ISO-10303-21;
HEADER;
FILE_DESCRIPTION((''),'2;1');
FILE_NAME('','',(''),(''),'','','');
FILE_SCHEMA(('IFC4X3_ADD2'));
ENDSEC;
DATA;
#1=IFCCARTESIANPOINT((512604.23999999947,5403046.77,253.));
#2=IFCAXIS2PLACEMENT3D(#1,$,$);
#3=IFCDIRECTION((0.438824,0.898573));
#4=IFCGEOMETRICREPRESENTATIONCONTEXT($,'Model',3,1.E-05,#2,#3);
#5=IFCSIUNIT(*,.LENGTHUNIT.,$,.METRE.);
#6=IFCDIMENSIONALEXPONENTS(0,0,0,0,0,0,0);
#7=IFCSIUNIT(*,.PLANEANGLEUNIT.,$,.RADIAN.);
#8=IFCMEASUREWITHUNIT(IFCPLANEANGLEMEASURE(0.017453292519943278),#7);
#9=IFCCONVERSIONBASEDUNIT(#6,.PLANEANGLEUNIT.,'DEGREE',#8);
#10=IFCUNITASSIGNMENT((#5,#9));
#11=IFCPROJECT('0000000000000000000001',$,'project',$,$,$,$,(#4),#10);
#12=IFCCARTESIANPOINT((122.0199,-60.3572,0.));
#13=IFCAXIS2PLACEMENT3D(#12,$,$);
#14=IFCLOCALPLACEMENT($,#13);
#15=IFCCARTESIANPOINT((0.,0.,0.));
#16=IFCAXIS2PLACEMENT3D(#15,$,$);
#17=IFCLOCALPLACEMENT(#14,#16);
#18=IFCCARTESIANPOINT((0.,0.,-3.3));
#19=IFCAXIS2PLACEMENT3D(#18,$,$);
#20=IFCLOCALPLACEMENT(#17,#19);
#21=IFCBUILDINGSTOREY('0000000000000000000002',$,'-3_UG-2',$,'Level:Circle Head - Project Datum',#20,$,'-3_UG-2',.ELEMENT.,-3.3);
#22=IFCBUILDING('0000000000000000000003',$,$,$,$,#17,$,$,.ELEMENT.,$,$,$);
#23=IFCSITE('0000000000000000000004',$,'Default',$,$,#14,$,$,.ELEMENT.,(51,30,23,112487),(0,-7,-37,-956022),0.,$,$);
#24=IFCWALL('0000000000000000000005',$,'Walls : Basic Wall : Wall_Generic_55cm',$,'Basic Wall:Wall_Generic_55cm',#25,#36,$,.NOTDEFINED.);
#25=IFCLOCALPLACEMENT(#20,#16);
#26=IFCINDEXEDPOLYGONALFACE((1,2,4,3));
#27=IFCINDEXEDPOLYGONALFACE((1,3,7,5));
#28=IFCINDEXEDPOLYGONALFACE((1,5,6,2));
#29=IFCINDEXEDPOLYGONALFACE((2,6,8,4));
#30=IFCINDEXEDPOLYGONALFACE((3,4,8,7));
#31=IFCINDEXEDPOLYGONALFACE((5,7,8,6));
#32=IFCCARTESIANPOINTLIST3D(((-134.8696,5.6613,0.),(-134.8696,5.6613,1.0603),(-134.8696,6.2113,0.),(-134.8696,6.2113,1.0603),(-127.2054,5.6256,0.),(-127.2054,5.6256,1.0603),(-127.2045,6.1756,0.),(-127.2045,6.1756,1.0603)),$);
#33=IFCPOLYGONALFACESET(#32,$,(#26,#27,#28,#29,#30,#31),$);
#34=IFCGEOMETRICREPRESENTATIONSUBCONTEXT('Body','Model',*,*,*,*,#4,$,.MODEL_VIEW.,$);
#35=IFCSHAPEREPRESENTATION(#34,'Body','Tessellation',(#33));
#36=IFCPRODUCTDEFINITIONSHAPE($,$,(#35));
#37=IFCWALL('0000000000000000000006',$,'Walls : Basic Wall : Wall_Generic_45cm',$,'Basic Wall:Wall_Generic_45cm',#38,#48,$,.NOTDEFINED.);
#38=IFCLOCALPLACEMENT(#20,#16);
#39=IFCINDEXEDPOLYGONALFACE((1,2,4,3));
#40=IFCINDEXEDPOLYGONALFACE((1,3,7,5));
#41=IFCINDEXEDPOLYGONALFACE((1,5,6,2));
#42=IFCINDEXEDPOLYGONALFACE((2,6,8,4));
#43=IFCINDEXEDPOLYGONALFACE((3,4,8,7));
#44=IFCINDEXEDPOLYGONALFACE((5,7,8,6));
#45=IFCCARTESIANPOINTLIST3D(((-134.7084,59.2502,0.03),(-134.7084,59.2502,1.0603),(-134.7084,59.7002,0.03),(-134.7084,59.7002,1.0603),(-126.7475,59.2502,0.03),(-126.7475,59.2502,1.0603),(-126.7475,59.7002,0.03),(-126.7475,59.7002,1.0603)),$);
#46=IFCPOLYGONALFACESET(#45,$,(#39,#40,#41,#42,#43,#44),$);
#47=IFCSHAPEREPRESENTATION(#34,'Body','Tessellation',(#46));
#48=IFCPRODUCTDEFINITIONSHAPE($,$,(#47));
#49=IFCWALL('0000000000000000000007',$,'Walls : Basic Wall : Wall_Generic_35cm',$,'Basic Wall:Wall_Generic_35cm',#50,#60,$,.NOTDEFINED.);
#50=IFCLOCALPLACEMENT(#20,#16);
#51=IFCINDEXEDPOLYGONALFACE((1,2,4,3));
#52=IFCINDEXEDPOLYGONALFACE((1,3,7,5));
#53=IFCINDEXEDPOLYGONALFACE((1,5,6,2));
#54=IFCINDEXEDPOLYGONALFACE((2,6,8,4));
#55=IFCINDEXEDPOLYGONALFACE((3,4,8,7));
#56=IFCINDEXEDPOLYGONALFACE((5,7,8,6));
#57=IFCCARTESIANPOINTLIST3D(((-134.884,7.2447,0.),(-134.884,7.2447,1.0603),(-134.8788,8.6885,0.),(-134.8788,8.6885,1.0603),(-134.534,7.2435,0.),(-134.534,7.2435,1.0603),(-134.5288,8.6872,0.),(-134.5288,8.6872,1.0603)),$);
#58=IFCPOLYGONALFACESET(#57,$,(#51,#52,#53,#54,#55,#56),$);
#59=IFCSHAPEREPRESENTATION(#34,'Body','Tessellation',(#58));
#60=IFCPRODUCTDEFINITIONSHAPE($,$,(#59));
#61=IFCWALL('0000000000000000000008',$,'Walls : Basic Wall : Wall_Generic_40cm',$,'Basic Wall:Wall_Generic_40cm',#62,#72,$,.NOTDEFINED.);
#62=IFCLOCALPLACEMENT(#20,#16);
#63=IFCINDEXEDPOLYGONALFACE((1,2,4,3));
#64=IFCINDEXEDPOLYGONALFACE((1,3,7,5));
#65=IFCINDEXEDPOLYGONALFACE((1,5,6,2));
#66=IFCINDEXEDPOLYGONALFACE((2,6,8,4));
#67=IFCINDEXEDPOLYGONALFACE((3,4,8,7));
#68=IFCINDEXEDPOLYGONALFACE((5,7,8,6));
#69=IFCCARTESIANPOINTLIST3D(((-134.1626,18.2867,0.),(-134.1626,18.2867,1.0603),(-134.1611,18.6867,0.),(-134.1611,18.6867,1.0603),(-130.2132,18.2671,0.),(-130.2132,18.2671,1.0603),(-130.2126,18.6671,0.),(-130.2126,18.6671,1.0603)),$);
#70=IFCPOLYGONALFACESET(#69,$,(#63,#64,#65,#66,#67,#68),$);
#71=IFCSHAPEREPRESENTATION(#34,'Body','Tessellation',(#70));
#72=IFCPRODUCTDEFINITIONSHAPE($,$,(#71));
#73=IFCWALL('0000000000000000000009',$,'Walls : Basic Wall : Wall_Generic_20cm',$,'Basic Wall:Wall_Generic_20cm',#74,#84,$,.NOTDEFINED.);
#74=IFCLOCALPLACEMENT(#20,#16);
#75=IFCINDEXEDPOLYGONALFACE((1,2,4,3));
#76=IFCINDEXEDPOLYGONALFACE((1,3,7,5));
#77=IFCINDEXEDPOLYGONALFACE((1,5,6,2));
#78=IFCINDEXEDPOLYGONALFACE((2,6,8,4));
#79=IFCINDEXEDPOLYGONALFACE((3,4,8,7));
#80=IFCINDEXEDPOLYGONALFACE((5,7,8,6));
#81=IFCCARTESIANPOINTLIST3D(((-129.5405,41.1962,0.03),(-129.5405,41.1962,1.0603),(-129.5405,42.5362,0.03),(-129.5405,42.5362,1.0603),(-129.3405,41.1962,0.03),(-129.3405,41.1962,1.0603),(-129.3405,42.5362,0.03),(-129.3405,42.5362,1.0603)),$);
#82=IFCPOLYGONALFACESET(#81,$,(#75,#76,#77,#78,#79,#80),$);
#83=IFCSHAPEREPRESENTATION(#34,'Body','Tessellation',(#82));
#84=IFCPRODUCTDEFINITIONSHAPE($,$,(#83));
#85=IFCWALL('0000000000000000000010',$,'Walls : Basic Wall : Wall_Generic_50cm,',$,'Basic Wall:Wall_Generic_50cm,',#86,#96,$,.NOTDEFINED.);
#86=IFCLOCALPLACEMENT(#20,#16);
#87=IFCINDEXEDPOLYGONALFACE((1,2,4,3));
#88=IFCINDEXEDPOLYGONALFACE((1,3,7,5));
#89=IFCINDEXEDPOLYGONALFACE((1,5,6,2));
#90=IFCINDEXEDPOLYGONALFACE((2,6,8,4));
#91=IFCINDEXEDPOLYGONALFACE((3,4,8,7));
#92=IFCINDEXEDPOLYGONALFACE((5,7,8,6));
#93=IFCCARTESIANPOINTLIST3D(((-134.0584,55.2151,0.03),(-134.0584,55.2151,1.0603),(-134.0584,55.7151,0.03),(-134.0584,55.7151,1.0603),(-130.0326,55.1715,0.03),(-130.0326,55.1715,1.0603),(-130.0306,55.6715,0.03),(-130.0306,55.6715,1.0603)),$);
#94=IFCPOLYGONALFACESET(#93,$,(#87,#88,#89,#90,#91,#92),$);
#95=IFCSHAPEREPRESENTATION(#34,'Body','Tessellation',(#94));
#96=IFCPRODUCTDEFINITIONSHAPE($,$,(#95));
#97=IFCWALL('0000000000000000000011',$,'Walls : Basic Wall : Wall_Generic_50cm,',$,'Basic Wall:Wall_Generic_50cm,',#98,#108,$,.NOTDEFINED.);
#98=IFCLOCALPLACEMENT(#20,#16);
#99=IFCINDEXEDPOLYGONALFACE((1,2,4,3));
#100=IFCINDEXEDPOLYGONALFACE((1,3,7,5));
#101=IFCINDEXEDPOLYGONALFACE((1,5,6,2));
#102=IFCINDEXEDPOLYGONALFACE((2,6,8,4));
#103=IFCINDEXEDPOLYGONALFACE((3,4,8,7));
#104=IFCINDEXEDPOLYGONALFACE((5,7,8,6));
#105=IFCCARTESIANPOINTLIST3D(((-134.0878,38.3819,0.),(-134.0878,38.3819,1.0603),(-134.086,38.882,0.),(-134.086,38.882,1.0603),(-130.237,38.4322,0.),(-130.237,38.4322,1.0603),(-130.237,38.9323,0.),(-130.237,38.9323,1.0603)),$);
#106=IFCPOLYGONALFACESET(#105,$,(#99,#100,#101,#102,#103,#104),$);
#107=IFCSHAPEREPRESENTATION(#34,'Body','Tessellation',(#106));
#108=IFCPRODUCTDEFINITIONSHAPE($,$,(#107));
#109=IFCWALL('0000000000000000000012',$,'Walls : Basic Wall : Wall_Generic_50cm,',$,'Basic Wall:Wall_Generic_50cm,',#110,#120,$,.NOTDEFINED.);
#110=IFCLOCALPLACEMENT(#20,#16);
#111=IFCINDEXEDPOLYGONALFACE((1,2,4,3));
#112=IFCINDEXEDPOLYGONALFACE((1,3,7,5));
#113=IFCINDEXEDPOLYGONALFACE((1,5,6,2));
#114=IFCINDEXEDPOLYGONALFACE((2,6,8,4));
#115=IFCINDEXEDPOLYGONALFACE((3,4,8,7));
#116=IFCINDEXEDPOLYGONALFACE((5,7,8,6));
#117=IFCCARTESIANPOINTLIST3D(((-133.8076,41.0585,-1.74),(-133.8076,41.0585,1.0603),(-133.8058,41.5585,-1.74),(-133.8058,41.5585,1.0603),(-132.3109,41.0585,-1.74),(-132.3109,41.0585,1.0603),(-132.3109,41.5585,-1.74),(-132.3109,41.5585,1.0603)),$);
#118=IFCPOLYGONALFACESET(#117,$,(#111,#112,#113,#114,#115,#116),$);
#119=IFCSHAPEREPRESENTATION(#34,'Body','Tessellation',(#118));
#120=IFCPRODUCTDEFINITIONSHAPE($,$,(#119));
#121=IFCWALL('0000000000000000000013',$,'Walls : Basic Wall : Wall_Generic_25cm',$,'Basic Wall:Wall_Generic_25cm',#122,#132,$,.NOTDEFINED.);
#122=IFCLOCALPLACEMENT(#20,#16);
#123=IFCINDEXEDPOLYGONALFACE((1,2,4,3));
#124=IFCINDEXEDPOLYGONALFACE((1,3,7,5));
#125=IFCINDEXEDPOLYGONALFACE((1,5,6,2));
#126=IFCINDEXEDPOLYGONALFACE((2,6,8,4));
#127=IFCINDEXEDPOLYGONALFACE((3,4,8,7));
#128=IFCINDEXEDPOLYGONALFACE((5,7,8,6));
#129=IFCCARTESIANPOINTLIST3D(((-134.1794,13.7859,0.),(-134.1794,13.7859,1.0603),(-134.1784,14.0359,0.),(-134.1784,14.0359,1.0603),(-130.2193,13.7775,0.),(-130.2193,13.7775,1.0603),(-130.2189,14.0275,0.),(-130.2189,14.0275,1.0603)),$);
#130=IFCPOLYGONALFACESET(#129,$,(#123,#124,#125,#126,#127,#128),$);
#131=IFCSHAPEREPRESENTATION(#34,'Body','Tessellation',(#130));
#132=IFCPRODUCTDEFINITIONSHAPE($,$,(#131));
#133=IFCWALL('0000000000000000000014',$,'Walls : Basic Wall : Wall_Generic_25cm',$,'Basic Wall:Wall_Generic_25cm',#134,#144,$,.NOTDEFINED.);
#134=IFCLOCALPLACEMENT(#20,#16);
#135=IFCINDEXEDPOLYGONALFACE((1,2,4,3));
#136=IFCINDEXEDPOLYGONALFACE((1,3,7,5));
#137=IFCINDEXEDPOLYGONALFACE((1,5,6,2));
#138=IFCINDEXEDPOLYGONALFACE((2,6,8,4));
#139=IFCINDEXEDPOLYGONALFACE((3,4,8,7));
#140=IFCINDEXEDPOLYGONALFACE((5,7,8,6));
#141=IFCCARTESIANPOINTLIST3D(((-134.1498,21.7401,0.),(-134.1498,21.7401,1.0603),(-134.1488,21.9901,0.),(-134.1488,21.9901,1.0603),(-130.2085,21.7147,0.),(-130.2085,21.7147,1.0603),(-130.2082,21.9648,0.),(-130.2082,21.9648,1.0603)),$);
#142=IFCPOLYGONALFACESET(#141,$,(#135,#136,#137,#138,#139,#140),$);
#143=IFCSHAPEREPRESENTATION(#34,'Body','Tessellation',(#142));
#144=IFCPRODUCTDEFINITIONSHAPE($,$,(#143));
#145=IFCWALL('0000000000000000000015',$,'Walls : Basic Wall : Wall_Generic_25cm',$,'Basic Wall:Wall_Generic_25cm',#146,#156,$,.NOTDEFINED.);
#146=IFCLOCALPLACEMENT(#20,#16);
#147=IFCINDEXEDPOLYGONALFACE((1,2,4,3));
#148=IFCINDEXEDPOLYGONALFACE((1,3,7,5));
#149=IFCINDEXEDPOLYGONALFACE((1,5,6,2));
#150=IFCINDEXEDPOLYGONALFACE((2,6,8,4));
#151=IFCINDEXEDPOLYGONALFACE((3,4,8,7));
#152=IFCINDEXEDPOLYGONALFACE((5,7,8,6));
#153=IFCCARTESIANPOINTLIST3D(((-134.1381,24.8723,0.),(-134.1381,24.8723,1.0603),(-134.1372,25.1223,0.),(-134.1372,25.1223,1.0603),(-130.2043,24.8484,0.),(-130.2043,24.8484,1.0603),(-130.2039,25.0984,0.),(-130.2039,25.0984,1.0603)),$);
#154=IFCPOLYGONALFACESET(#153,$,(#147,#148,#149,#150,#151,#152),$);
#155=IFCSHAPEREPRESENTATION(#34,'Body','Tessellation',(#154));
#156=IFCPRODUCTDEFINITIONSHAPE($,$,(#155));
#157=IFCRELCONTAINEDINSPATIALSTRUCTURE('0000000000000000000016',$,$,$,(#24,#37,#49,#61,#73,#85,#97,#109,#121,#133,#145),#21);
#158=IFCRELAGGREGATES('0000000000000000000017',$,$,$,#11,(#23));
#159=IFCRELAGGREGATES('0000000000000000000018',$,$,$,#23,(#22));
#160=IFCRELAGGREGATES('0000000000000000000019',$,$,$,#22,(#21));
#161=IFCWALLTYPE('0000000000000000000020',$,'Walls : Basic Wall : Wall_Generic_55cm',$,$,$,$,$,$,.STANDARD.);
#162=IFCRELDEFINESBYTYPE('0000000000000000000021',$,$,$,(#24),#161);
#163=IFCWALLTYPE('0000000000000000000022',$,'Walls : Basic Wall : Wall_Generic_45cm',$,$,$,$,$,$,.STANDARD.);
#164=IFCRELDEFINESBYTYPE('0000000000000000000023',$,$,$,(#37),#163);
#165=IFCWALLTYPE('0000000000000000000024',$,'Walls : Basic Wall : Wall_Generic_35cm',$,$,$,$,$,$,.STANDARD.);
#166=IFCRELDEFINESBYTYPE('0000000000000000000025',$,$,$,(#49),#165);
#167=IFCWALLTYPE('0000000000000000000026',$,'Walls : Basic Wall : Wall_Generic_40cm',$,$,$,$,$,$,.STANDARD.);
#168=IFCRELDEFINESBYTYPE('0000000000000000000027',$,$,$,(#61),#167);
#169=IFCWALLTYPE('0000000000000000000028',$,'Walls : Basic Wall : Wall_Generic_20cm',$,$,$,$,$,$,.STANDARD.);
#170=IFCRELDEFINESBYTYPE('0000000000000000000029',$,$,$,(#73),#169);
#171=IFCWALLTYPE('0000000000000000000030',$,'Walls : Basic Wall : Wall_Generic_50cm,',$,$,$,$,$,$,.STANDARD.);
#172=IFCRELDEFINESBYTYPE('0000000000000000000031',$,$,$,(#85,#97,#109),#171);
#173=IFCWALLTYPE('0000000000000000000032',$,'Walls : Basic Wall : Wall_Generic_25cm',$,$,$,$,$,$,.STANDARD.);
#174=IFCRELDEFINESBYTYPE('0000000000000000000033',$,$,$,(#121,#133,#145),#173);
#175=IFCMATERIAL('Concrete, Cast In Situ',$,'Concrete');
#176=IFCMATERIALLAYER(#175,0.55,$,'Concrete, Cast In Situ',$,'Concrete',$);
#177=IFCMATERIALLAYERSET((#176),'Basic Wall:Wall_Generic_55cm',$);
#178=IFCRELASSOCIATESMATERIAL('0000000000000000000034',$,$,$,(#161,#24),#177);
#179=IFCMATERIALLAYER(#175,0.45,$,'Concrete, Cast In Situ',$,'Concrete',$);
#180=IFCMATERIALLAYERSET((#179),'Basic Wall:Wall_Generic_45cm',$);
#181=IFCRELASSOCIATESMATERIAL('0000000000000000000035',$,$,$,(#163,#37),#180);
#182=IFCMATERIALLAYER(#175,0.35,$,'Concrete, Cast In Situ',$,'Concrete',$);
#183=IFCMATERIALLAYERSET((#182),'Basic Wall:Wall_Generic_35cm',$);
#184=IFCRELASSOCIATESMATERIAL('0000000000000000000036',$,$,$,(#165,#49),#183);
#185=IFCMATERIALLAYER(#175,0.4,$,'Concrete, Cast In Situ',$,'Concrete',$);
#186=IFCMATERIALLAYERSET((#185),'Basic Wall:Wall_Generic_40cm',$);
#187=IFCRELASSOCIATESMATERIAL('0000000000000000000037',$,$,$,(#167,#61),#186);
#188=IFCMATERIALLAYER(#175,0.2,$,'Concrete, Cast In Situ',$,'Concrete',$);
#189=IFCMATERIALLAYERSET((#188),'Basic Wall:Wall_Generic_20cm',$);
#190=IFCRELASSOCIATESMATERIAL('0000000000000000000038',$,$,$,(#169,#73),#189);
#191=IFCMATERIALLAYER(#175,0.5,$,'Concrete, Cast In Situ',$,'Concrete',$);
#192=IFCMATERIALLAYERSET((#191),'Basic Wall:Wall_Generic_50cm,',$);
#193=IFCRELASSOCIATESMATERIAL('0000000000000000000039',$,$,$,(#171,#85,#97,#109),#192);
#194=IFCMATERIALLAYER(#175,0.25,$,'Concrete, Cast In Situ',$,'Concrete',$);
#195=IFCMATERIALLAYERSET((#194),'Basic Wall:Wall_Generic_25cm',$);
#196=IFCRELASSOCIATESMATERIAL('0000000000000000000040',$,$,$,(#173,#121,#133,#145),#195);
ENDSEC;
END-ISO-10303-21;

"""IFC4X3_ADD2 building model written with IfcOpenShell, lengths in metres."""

from ifc_helpers import new_model, entity, si_unit, converted_unit, direction, frame, frame_2d, origin, place, context, subcontext, project, spatial, polyline, rectangle, outline, extrude, clip, halfspace, material, layer, layer_set, type_object, element, save


model = new_model("IFC4X3_ADD2")

# Units and contexts
model_context = context("Model", 3, precision=1e-05, world=frame((512604.23999999947, 5403046.77, 253.0)), true_north=direction((0.438824, 0.898573)))
body_context = subcontext(model_context, "Body", "Model", "MODEL_VIEW")
ifc_project = project(units=[si_unit("LENGTHUNIT", "METRE"), converted_unit("PLANEANGLEUNIT", "DEGREE", entity("IfcPlaneAngleMeasure", 0.017453292519943278), si_unit("PLANEANGLEUNIT", "RADIAN"), dimensions=[0, 0, 0, 0, 0, 0, 0])], contexts=[model_context])

# Site, building, storey
site_placement = place(None, frame((122.0199, -60.3572, 0.0)))
site = spatial("IfcSite", under=ifc_project, at=site_placement, Name="Default", CompositionType="ELEMENT", RefLatitude=(51, 30, 23, 112487), RefLongitude=(0, -7, -37, -956022), RefElevation=0.0)
building_placement = place(site_placement, origin())
building = spatial("IfcBuilding", under=site, at=building_placement, CompositionType="ELEMENT")
storey_placement = place(building_placement, frame((0.0, 0.0, -3.3)))
storey = spatial("IfcBuildingStorey", under=building, at=storey_placement, Name="-3_UG-2", ObjectType="Level:Circle Head - Project Datum", LongName="-3_UG-2", CompositionType="ELEMENT", Elevation=-3.3)

# Walls
ifc_material_1 = material(Name="Concrete, Cast In Situ", Category="Concrete")
ifc_layer_1 = layer(ifc_material_1, 0.55, Name="Concrete, Cast In Situ", Category="Concrete")
ifc_layer_set_1 = layer_set([ifc_layer_1], Name="Basic Wall:Wall_Generic_55cm")
wall_type_1 = type_object("IfcWallType", Name="Walls : Basic Wall : Wall_Generic_55cm", PredefinedType="STANDARD", material=ifc_layer_set_1)
wall_1_placement = place(storey_placement, frame((-134.8709, 5.9363, 0.0), z_axis=(0.0, 0.0, 1.0), x_axis=(0.999989, -0.004647, 0.0)))
element("IfcWall", 1, at=wall_1_placement, inside=storey, type_object=wall_type_1, material=ifc_layer_set_1, Name="Walls : Basic Wall : Wall_Generic_55cm", ObjectType="Basic Wall:Wall_Generic_55cm", PredefinedType="NOTDEFINED", context=body_context, shape_type="Clipping", body=[
    clip(extrude(outline(polyline([(7.6669, -0.275), (7.6652, 0.275), (7.4503, 0.275), (0.0, 0.275), (0.0026, -0.275), (7.6669, -0.275)])), origin(), (0.0, 0.0, 1.0), 1.0603), halfspace(origin(), True)),
])
ifc_layer_2 = layer(ifc_material_1, 0.45, Name="Concrete, Cast In Situ", Category="Concrete")
ifc_layer_set_2 = layer_set([ifc_layer_2], Name="Basic Wall:Wall_Generic_45cm")
wall_type_2 = type_object("IfcWallType", Name="Walls : Basic Wall : Wall_Generic_45cm", PredefinedType="STANDARD", material=ifc_layer_set_2)
wall_2_placement = place(storey_placement, frame((-134.7084, 59.4752, 0.03)))
element("IfcWall", 2, at=wall_2_placement, inside=storey, type_object=wall_type_2, material=ifc_layer_set_2, Name="Walls : Basic Wall : Wall_Generic_45cm", ObjectType="Basic Wall:Wall_Generic_45cm", PredefinedType="NOTDEFINED", context=body_context, shape_type="Clipping", body=[
    clip(extrude(rectangle(XDim=7.9609, YDim=0.45, at=frame_2d((3.9805, 0.0), x_axis=(-1.0, 0.0))), origin(), (0.0, 0.0, 1.0), 1.0303), halfspace(origin(), True)),
])
ifc_layer_3 = layer(ifc_material_1, 0.35, Name="Concrete, Cast In Situ", Category="Concrete")
ifc_layer_set_3 = layer_set([ifc_layer_3], Name="Basic Wall:Wall_Generic_35cm")
wall_type_3 = type_object("IfcWallType", Name="Walls : Basic Wall : Wall_Generic_35cm", PredefinedType="STANDARD", material=ifc_layer_set_3)
wall_3_placement = place(storey_placement, frame((-134.7038, 8.6879, 0.0), z_axis=(0.0, 0.0, 1.0), x_axis=(-0.003592, -0.999994, 0.0)))
element("IfcWall", 3, at=wall_3_placement, inside=storey, type_object=wall_type_3, material=ifc_layer_set_3, Name="Walls : Basic Wall : Wall_Generic_35cm", ObjectType="Basic Wall:Wall_Generic_35cm", PredefinedType="NOTDEFINED", context=body_context, shape_type="Clipping", body=[
    clip(extrude(outline(polyline([(1.4438, -0.175), (1.4438, 0.175), (0.0, 0.175), (0.0, -0.175), (1.4438, -0.175)])), origin(), (0.0, 0.0, 1.0), 1.0603), halfspace(origin(), True)),
])
ifc_layer_4 = layer(ifc_material_1, 0.4, Name="Concrete, Cast In Situ", Category="Concrete")
ifc_layer_set_4 = layer_set([ifc_layer_4], Name="Basic Wall:Wall_Generic_40cm")
wall_type_4 = type_object("IfcWallType", Name="Walls : Basic Wall : Wall_Generic_40cm", PredefinedType="STANDARD", material=ifc_layer_set_4)
wall_4_placement = place(storey_placement, frame((-134.1621, 18.4867, 0.0), z_axis=(0.0, 0.0, 1.0), x_axis=(0.999988, -0.004955, 0.0)))
element("IfcWall", 4, at=wall_4_placement, inside=storey, type_object=wall_type_4, material=ifc_layer_set_4, Name="Walls : Basic Wall : Wall_Generic_40cm", ObjectType="Basic Wall:Wall_Generic_40cm", PredefinedType="NOTDEFINED", context=body_context, shape_type="Clipping", body=[
    clip(extrude(outline(polyline([(3.95, -0.2), (3.9486, 0.2), (0.0, 0.2), (0.0005, -0.2), (3.95, -0.2)])), origin(), (0.0, 0.0, 1.0), 1.0603), halfspace(origin(), True)),
])
ifc_layer_5 = layer(ifc_material_1, 0.2, Name="Concrete, Cast In Situ", Category="Concrete")
ifc_layer_set_5 = layer_set([ifc_layer_5], Name="Basic Wall:Wall_Generic_20cm")
wall_type_5 = type_object("IfcWallType", Name="Walls : Basic Wall : Wall_Generic_20cm", PredefinedType="STANDARD", material=ifc_layer_set_5)
wall_5_placement = place(storey_placement, frame((-129.4405, 42.5362, 0.03), z_axis=(0.0, 0.0, 1.0), x_axis=(0.0, -1.0, 0.0)))
element("IfcWall", 5, at=wall_5_placement, inside=storey, type_object=wall_type_5, material=ifc_layer_set_5, Name="Walls : Basic Wall : Wall_Generic_20cm", ObjectType="Basic Wall:Wall_Generic_20cm", PredefinedType="NOTDEFINED", context=body_context, shape_type="Clipping", body=[
    clip(extrude(rectangle(XDim=1.34, YDim=0.2, at=frame_2d((0.67, 0.0), x_axis=(-1.0, 0.0))), origin(), (0.0, 0.0, 1.0), 1.0303), halfspace(origin(), True)),
])
ifc_layer_6 = layer(ifc_material_1, 0.5, Name="Concrete, Cast In Situ", Category="Concrete")
ifc_layer_set_6 = layer_set([ifc_layer_6], Name="Basic Wall:Wall_Generic_50cm,")
wall_type_6 = type_object("IfcWallType", Name="Walls : Basic Wall : Wall_Generic_50cm,", PredefinedType="STANDARD", material=ifc_layer_set_6)
wall_6_placement = place(storey_placement, frame((-134.0611, 55.4651, 0.03), z_axis=(0.0, 0.0, 1.0), x_axis=(0.999941, -0.010818, 0.0)))
element("IfcWall", 6, at=wall_6_placement, inside=storey, type_object=wall_type_6, material=ifc_layer_set_6, Name="Walls : Basic Wall : Wall_Generic_50cm,", ObjectType="Basic Wall:Wall_Generic_50cm,", PredefinedType="NOTDEFINED", context=body_context, shape_type="Clipping", body=[
    clip(extrude(outline(polyline([(4.0315, -0.25), (4.028, 0.25), (0.0, 0.25), (0.0054, -0.25), (4.0315, -0.25)])), origin(), (0.0, 0.0, 1.0), 1.0303), halfspace(origin(), True)),
])
wall_7_placement = place(storey_placement, frame((-134.0911, 38.6319, 0.0), z_axis=(0.0, 0.0, 1.0), x_axis=(0.999915, 0.013063, 0.0)))
element("IfcWall", 7, at=wall_7_placement, inside=storey, type_object=wall_type_6, material=ifc_layer_set_6, Name="Walls : Basic Wall : Wall_Generic_50cm,", ObjectType="Basic Wall:Wall_Generic_50cm,", PredefinedType="NOTDEFINED", context=body_context, shape_type="Clipping", body=[
    clip(extrude(outline(polyline([(3.8512, -0.25), (3.8577, 0.25), (0.0084, 0.25), (0.0, -0.25), (3.8512, -0.25)])), origin(), (0.0, 0.0, 1.0), 1.0603), halfspace(origin(), True)),
])
wall_8_placement = place(storey_placement, frame((-133.8076, 41.3085, -1.74)))
element("IfcWall", 8, at=wall_8_placement, inside=storey, type_object=wall_type_6, material=ifc_layer_set_6, Name="Walls : Basic Wall : Wall_Generic_50cm,", ObjectType="Basic Wall:Wall_Generic_50cm,", PredefinedType="NOTDEFINED", context=body_context, shape_type="Clipping", body=[
    clip(extrude(outline(polyline([(1.4968, -0.25), (1.4968, 0.25), (0.0018, 0.25), (0.0, -0.25), (1.4968, -0.25)])), origin(), (0.0, 0.0, 1.0), 2.8003), halfspace(frame((0.0, 0.0, -1.74)), True)),
])
ifc_layer_7 = layer(ifc_material_1, 0.25, Name="Concrete, Cast In Situ", Category="Concrete")
ifc_layer_set_7 = layer_set([ifc_layer_7], Name="Basic Wall:Wall_Generic_25cm")
wall_type_7 = type_object("IfcWallType", Name="Walls : Basic Wall : Wall_Generic_25cm", PredefinedType="STANDARD", material=ifc_layer_set_7)
wall_9_placement = place(storey_placement, frame((-134.1791, 13.9109, 0.0), z_axis=(0.0, 0.0, 1.0), x_axis=(0.999998, -0.002121, 0.0)))
element("IfcWall", 9, at=wall_9_placement, inside=storey, type_object=wall_type_7, material=ifc_layer_set_7, Name="Walls : Basic Wall : Wall_Generic_25cm", ObjectType="Basic Wall:Wall_Generic_25cm", PredefinedType="NOTDEFINED", context=body_context, shape_type="Clipping", body=[
    clip(extrude(outline(polyline([(3.9601, -0.125), (3.9599, 0.125), (0.0004, 0.125), (0.0, -0.125), (3.9601, -0.125)])), origin(), (0.0, 0.0, 1.0), 1.0603), halfspace(origin(), True)),
])
wall_10_placement = place(storey_placement, frame((-134.1497, 21.8651, 0.0), z_axis=(0.0, 0.0, 1.0), x_axis=(0.999979, -0.006441, 0.0)))
element("IfcWall", 10, at=wall_10_placement, inside=storey, type_object=wall_type_7, material=ifc_layer_set_7, Name="Walls : Basic Wall : Wall_Generic_25cm", ObjectType="Basic Wall:Wall_Generic_25cm", PredefinedType="NOTDEFINED", context=body_context, shape_type="Clipping", body=[
    clip(extrude(outline(polyline([(3.942, -0.125), (3.9408, 0.125), (0.0, 0.125), (0.0007, -0.125), (3.942, -0.125)])), origin(), (0.0, 0.0, 1.0), 1.0603), halfspace(origin(), True)),
])
wall_11_placement = place(storey_placement, frame((-134.138, 24.9973, 0.0), z_axis=(0.0, 0.0, 1.0), x_axis=(0.999981, -0.006087, 0.0)))
element("IfcWall", 11, at=wall_11_placement, inside=storey, type_object=wall_type_7, material=ifc_layer_set_7, Name="Walls : Basic Wall : Wall_Generic_25cm", ObjectType="Basic Wall:Wall_Generic_25cm", PredefinedType="NOTDEFINED", context=body_context, shape_type="Clipping", body=[
    clip(extrude(outline(polyline([(3.9345, -0.125), (3.9333, 0.125), (0.0, 0.125), (0.0006, -0.125), (3.9345, -0.125)])), origin(), (0.0, 0.0, 1.0), 1.0603), halfspace(origin(), True)),
])

save(model, "model.ifc")
